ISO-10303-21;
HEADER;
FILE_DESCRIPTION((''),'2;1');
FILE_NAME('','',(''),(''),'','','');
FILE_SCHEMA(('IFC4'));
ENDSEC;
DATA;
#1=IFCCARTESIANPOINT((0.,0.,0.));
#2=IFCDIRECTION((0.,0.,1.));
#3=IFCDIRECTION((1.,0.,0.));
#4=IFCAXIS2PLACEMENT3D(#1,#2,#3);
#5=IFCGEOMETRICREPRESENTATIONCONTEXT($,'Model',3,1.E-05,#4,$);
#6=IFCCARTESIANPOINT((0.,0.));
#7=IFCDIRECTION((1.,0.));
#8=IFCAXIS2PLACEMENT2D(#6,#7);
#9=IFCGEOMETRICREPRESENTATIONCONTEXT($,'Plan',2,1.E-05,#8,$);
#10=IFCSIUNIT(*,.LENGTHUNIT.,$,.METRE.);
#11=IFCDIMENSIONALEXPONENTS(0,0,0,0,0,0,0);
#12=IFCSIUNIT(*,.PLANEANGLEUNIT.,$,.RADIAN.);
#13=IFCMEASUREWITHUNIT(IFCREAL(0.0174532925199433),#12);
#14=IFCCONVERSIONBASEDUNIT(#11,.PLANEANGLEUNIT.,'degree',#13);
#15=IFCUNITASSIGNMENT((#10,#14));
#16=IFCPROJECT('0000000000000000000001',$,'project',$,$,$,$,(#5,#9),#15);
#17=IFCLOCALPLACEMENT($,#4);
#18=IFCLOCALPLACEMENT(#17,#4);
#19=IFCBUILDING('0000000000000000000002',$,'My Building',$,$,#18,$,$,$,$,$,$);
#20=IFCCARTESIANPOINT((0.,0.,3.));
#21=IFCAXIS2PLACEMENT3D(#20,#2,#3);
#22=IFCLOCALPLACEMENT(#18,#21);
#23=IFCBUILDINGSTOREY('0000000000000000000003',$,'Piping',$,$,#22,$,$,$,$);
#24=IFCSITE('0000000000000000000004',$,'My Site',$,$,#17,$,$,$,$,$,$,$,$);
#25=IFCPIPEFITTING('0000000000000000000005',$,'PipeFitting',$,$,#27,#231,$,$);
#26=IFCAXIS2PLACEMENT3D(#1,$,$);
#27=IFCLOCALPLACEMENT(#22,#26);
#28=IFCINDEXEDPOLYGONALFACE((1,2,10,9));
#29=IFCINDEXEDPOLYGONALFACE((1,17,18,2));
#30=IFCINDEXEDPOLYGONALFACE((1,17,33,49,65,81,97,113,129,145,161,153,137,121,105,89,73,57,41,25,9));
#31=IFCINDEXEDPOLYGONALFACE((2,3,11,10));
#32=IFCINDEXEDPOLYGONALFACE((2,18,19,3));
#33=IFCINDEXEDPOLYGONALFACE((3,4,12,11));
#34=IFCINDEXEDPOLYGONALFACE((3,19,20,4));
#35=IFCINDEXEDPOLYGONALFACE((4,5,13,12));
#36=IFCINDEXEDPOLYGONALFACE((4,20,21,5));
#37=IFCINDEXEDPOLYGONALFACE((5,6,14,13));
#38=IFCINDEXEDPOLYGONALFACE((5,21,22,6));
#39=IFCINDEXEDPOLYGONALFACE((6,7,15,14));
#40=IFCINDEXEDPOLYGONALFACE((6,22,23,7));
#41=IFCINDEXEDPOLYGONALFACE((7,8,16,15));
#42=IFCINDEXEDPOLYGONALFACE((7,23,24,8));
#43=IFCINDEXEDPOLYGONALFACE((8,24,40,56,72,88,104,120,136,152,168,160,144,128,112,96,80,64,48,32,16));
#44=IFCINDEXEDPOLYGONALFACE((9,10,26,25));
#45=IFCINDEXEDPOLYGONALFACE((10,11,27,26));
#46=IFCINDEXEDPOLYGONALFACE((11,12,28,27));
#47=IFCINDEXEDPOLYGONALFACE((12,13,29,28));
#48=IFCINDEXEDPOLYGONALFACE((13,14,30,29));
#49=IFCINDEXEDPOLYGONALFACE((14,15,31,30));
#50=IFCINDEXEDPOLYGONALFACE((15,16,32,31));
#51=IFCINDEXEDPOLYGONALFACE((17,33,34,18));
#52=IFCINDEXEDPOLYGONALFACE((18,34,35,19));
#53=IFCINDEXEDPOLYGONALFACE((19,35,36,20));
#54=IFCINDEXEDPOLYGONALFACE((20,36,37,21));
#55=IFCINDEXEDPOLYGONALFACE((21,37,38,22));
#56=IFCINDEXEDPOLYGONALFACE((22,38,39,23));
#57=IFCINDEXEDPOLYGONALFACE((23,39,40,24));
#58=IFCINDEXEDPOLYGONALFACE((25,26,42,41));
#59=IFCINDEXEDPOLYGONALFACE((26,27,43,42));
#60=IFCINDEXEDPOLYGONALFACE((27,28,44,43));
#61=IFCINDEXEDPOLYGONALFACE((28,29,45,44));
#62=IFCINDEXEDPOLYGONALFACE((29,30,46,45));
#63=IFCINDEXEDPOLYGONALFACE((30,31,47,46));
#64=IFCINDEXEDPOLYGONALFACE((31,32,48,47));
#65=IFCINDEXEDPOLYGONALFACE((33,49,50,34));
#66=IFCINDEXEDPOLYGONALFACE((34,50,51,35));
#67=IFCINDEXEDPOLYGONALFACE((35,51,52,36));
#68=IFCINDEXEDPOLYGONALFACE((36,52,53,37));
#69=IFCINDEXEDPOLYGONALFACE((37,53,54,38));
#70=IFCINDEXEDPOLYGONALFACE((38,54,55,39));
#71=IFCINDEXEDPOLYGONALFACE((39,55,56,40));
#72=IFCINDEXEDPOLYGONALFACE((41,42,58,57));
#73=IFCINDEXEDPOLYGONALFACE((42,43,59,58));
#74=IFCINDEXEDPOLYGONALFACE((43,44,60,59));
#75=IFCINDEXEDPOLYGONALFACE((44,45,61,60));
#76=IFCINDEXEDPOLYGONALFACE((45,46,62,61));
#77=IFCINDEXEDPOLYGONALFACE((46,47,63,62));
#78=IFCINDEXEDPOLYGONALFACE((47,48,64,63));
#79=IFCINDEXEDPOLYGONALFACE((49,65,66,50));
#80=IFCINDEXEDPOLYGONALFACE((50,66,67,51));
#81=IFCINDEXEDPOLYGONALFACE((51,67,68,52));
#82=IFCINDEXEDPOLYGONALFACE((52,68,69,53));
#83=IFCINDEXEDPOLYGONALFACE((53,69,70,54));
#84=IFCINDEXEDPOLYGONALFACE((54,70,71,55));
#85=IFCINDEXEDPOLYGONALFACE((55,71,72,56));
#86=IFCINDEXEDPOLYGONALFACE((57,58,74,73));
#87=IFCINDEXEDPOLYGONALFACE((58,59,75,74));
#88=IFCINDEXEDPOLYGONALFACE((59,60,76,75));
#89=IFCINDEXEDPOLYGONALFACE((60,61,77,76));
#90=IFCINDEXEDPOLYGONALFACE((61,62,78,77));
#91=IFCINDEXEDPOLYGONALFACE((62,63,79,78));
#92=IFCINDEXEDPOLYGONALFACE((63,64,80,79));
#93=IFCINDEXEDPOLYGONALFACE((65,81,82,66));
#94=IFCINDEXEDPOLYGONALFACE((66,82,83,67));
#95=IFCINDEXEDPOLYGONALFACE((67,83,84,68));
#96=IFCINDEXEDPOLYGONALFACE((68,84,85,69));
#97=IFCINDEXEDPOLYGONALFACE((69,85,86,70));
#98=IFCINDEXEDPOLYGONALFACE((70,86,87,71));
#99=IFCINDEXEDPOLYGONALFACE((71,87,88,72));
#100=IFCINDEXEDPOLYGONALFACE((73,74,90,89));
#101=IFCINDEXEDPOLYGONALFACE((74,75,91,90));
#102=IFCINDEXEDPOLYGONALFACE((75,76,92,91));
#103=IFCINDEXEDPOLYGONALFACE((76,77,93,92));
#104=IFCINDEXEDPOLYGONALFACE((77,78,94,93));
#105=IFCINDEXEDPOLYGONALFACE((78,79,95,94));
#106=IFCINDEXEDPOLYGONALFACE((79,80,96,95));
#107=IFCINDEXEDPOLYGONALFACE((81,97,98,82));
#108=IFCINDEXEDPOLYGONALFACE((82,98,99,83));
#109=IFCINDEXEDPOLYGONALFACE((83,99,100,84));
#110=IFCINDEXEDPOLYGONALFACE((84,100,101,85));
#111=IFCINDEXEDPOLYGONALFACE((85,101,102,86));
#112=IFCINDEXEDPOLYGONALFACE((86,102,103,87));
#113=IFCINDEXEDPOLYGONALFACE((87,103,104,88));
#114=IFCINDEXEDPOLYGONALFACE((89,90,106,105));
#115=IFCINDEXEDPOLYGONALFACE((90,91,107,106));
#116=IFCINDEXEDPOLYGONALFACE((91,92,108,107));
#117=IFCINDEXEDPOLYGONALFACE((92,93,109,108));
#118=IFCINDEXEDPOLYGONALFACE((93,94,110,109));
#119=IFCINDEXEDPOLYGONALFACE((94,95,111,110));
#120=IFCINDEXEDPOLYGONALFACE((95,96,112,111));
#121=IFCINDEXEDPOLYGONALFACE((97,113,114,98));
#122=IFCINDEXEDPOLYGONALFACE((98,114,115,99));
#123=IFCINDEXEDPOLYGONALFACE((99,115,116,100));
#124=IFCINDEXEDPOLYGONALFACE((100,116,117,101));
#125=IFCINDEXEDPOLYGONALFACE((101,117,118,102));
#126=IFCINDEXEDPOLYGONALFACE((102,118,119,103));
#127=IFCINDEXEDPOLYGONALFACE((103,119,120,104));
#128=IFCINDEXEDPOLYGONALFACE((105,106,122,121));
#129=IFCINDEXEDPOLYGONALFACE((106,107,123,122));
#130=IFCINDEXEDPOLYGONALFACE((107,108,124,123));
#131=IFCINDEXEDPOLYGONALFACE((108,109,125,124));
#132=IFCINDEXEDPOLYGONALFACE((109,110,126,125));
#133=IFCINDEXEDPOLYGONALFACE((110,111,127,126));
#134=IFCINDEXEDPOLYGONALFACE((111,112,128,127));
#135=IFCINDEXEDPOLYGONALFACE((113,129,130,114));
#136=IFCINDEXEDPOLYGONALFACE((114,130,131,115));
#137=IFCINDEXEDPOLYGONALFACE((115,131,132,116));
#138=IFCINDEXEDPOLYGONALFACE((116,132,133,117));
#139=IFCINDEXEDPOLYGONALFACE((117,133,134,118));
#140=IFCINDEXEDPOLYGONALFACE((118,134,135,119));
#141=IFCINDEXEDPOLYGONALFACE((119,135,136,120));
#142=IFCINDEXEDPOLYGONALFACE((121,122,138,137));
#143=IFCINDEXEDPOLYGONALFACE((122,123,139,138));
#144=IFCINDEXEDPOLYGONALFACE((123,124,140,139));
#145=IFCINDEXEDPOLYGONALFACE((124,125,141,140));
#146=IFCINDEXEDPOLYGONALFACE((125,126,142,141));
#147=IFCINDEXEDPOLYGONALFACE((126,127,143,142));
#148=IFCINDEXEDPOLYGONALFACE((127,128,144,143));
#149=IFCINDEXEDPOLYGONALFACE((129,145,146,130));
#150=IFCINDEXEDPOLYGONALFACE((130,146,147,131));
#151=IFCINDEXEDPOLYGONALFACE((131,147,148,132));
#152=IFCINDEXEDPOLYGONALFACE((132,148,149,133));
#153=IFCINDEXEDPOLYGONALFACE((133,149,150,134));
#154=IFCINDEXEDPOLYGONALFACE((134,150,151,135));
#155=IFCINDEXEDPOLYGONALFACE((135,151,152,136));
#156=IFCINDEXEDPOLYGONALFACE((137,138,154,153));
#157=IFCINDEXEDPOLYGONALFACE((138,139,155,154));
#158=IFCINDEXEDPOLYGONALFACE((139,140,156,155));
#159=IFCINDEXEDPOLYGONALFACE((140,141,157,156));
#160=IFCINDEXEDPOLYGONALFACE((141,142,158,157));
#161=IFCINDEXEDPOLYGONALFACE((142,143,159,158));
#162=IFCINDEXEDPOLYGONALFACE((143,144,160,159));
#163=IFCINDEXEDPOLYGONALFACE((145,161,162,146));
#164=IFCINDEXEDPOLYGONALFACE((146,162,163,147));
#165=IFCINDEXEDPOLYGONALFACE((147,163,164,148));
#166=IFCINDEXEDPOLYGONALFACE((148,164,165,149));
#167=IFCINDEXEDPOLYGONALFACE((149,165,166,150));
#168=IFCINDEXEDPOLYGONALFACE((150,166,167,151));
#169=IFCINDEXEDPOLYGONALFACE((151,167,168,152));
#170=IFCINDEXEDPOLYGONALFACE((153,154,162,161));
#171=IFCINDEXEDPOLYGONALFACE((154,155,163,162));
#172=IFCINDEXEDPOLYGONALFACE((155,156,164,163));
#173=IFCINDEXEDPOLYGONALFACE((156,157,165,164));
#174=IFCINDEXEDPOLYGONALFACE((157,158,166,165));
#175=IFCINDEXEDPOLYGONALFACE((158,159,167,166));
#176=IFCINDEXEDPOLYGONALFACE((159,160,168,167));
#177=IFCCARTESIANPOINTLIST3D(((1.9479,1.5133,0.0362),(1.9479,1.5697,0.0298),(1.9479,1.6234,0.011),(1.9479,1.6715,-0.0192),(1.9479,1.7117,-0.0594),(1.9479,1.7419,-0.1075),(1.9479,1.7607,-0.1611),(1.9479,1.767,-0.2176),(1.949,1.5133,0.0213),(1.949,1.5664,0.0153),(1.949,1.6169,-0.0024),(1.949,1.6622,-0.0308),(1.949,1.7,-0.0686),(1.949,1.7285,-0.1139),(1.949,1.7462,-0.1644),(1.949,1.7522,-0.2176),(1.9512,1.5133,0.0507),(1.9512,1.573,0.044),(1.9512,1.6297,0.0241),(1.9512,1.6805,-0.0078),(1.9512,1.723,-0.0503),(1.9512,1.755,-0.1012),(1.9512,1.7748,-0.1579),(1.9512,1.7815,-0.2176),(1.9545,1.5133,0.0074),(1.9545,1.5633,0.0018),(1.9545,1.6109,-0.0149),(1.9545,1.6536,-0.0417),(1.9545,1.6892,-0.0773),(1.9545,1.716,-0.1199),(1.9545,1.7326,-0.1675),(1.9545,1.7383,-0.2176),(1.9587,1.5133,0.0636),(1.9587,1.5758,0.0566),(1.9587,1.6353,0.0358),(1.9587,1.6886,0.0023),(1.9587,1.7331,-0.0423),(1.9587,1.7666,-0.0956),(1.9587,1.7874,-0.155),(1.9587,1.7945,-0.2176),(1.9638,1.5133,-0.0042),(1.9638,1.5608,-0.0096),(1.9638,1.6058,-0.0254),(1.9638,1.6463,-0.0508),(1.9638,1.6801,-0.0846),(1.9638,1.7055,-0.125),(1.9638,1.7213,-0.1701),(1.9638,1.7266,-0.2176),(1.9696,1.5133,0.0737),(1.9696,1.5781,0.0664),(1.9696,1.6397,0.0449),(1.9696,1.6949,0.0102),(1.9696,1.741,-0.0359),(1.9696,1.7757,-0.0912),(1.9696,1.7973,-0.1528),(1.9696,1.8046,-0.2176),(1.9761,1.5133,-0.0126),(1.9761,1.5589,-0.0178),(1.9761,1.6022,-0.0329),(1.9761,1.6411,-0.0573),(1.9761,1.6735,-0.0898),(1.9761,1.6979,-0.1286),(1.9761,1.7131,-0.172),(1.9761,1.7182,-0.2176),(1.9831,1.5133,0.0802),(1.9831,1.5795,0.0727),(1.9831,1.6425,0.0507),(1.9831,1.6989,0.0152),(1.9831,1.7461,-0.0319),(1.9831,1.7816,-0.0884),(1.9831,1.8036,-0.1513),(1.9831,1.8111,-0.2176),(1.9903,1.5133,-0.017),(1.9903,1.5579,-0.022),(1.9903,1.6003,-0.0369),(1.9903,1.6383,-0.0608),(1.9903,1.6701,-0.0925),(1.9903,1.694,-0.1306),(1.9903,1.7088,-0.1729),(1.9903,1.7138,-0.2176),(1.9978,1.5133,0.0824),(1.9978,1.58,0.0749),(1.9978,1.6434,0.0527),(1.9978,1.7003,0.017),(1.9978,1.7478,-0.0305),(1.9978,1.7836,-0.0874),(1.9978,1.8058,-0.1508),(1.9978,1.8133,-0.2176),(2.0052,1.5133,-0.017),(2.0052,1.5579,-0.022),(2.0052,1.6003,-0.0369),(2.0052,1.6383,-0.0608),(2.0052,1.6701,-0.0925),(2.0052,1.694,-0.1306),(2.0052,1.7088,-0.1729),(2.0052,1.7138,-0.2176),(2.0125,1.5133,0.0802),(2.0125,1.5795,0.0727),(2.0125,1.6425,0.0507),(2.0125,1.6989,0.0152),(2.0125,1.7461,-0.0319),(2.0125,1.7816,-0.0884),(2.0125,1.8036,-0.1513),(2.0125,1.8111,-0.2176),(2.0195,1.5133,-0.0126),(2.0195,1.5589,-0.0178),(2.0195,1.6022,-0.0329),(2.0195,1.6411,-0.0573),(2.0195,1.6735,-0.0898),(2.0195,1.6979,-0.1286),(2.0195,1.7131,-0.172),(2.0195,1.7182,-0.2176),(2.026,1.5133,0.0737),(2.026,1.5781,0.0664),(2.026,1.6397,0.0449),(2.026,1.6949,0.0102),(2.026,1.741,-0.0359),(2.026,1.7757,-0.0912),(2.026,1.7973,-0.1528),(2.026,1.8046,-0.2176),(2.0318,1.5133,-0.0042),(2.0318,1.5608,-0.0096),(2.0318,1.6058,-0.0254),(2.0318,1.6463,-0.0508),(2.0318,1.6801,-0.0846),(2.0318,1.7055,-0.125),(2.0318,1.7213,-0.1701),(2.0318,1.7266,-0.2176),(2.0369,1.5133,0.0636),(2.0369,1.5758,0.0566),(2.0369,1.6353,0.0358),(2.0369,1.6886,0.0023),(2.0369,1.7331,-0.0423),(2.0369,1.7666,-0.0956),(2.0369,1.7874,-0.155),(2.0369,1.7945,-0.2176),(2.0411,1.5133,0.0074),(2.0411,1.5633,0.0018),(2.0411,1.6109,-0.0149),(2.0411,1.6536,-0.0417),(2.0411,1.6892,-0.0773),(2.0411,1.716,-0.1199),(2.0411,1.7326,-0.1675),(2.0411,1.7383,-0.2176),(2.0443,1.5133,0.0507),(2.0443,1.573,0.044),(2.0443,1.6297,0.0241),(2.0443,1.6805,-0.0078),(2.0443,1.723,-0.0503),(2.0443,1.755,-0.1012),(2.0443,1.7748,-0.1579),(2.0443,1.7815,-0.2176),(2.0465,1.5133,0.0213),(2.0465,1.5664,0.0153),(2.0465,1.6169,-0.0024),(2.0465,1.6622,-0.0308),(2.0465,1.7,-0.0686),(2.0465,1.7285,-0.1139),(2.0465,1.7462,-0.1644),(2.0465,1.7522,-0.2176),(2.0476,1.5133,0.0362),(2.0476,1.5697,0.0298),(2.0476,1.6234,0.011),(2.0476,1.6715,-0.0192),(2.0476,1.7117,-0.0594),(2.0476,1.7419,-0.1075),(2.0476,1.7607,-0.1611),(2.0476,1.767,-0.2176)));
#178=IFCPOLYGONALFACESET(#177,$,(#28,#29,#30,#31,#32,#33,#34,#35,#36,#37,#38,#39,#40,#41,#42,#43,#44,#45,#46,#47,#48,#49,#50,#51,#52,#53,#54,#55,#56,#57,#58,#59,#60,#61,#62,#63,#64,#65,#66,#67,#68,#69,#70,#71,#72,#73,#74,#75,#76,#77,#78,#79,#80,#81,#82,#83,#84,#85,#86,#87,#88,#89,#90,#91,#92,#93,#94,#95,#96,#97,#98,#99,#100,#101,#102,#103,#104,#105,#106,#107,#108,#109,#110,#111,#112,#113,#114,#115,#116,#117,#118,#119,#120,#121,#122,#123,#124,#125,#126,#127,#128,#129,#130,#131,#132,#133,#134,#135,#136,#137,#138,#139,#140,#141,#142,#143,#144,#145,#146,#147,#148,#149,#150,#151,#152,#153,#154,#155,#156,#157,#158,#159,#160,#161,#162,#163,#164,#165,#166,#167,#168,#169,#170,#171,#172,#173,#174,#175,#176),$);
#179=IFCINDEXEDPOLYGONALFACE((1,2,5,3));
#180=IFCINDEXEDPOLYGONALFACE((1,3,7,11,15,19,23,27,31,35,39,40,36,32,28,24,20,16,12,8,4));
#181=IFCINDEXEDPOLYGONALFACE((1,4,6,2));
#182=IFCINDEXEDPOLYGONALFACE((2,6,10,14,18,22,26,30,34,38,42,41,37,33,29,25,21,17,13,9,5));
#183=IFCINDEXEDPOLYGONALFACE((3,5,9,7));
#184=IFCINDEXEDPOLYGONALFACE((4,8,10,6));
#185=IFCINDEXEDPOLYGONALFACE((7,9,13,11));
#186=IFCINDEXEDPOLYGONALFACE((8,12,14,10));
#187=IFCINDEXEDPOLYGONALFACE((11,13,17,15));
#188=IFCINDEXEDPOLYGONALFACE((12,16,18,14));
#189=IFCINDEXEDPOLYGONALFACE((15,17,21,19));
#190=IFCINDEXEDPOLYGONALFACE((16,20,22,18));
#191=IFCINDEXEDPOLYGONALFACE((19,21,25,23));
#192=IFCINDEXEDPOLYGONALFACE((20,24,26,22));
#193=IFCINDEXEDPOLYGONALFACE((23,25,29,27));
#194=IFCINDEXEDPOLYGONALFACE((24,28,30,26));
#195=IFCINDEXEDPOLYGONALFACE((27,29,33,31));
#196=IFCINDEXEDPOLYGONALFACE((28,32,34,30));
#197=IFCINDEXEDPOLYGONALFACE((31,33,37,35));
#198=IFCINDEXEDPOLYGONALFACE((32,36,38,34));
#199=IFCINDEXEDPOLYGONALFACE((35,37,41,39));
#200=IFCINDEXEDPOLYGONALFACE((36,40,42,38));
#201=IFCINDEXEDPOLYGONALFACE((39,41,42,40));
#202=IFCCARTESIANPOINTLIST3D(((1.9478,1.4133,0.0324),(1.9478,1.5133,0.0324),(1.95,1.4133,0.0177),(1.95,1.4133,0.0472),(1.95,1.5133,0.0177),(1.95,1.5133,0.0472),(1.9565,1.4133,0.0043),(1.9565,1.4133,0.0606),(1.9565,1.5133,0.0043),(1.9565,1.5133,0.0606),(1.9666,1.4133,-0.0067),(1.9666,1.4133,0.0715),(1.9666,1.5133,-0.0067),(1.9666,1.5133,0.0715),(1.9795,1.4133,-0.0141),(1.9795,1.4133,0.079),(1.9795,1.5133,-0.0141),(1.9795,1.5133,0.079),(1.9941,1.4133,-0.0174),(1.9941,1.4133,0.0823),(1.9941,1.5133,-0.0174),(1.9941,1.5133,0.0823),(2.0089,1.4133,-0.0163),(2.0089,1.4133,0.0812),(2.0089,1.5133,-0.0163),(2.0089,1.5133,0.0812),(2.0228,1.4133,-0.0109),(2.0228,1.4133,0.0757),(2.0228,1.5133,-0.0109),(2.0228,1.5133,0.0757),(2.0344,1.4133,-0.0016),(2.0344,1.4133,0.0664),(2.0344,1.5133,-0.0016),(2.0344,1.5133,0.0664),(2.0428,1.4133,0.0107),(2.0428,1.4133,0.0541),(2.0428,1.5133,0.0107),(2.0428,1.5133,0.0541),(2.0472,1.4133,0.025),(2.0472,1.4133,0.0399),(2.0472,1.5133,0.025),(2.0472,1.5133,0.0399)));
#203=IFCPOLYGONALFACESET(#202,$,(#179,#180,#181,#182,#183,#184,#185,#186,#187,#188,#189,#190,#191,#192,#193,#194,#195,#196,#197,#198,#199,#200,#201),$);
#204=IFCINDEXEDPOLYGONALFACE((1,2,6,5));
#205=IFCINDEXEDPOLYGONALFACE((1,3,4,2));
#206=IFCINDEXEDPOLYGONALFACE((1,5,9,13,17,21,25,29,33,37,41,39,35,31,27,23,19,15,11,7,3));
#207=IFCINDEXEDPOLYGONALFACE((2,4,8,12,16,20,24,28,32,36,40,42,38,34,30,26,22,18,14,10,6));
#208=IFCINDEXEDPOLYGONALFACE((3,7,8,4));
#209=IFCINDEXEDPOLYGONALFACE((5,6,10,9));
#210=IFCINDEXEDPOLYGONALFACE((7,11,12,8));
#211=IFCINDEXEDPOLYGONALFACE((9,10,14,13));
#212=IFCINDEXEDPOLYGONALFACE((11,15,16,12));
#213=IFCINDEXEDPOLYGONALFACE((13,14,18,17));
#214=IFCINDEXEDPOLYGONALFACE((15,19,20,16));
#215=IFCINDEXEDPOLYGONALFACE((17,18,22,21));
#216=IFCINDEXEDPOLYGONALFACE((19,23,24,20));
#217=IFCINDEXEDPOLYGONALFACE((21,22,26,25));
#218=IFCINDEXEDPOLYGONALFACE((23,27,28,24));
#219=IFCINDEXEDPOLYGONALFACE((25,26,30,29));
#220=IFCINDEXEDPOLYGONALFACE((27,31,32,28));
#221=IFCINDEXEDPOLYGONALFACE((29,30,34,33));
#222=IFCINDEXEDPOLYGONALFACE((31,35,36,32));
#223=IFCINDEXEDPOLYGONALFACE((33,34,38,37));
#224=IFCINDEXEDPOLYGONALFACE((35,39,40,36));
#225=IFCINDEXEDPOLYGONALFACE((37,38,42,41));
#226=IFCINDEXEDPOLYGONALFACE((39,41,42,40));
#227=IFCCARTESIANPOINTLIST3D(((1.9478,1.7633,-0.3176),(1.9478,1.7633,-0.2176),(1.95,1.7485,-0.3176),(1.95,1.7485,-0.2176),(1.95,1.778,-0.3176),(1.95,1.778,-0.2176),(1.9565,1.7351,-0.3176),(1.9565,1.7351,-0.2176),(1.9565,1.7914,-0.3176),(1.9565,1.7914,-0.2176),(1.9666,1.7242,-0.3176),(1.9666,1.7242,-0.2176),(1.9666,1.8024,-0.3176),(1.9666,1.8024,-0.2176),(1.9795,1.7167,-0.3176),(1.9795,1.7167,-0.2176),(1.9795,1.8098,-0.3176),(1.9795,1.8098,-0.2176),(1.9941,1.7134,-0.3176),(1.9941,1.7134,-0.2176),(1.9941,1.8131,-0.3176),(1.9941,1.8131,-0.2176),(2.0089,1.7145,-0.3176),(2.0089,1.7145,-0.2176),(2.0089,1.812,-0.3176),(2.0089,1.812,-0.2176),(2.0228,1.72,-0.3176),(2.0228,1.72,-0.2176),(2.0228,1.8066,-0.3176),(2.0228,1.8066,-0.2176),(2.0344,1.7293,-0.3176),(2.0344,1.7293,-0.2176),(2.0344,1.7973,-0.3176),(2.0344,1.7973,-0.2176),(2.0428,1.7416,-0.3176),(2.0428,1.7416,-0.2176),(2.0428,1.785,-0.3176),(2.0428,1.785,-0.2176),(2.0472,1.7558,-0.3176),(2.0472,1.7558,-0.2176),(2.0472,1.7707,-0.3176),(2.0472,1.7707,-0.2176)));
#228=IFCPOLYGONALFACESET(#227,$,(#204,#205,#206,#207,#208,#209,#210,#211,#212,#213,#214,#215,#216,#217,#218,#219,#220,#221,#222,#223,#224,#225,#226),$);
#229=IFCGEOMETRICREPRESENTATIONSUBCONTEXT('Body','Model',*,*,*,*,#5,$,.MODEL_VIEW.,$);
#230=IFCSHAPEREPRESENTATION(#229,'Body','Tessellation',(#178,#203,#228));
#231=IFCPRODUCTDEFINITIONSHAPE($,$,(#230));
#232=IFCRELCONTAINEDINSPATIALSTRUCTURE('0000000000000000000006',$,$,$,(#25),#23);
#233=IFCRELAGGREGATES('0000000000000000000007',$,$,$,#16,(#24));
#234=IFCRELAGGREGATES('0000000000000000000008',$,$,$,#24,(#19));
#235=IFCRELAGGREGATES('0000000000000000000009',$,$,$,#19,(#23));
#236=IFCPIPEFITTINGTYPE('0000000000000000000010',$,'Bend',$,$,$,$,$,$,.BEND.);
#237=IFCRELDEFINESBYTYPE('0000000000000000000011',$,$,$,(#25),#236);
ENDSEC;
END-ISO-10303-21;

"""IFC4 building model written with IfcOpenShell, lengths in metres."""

from ifc_helpers import new_model, entity, si_unit, converted_unit, frame, origin_with_axes, origin_2d_with_axis, place, context, subcontext, project, spatial, circle, extrude, source, transform, mapped, type_object, type_shapes, element, save


model = new_model("IFC4")

# Units and contexts
model_context = context("Model", 3, precision=1e-05, world=origin_with_axes())
plan_context = context("Plan", 2, precision=1e-05, world=origin_2d_with_axis())
body_context = subcontext(model_context, "Body", "Model", "MODEL_VIEW")
ifc_project = project(units=[si_unit("LENGTHUNIT", "METRE"), converted_unit("PLANEANGLEUNIT", "degree", entity("IfcReal", 0.0174532925199433), si_unit("PLANEANGLEUNIT", "RADIAN"), dimensions=[0, 0, 0, 0, 0, 0, 0])], contexts=[model_context, plan_context])

# Site, building, storey
site_placement = place(None, origin_with_axes())
site = spatial("IfcSite", under=ifc_project, at=site_placement, Name="My Site")
building_placement = place(site_placement, origin_with_axes())
building = spatial("IfcBuilding", under=site, at=building_placement, Name="My Building")
storey_placement = place(building_placement, frame((0.0, 0.0, 3.0), z_axis=(0.0, 0.0, 1.0), x_axis=(1.0, 0.0, 0.0)))
storey = spatial("IfcBuildingStorey", under=building, at=storey_placement, Name="Piping")

# Pipe fitting
pipe_fitting_type_1 = type_object("IfcPipeFittingType", Name="Bend", PredefinedType="BEND")
shared_shape_1 = source(origin_with_axes(), body_context, "Body", "SolidModel", [
    entity("IfcSweptDiskSolid", entity("IfcIndexedPolyCurve", entity("IfcCartesianPointList3D", [[0.0, 0.0, 0.1], [0.0, -0.0732, 0.2768], [0.0, -0.25, 0.35]]), [entity("IfcArcIndex", [1, 2, 3])]), 0.05),
    extrude(circle(Radius=0.05), origin_with_axes(), (0.0, 0.0, 1.0), 0.1),
    extrude(circle(Radius=0.05), frame((0.0, -0.25, 0.35), z_axis=(0.0, -1.0, 0.0), x_axis=(1.0, 0.0, 0.0)), (0.0, 0.0, 1.0), 0.1),
])
type_shapes(pipe_fitting_type_1, [shared_shape_1])
for number, where, z_axis, x_axis, name in (
    (1, (1.9978, 1.4133, 0.0324), (0.0, 1.0, 0.0), (-1.0, 0.0, 0.0), "PipeFitting"),
):
    element("IfcPipeFitting", number, at=place(storey_placement, frame(where, z_axis=z_axis, x_axis=x_axis)), inside=storey, type_object=pipe_fitting_type_1, Name=name, context=body_context, shape_type="MappedRepresentation", body=[
        mapped(shared_shape_1, transform((0.0, 0.0, 0.0), x_axis=(1.0, 0.0, 0.0), y_axis=(0.0, 1.0, 0.0), z_axis=(0.0, 0.0, 1.0), scale=1.0)),
    ])

save(model, "model.ifc")
